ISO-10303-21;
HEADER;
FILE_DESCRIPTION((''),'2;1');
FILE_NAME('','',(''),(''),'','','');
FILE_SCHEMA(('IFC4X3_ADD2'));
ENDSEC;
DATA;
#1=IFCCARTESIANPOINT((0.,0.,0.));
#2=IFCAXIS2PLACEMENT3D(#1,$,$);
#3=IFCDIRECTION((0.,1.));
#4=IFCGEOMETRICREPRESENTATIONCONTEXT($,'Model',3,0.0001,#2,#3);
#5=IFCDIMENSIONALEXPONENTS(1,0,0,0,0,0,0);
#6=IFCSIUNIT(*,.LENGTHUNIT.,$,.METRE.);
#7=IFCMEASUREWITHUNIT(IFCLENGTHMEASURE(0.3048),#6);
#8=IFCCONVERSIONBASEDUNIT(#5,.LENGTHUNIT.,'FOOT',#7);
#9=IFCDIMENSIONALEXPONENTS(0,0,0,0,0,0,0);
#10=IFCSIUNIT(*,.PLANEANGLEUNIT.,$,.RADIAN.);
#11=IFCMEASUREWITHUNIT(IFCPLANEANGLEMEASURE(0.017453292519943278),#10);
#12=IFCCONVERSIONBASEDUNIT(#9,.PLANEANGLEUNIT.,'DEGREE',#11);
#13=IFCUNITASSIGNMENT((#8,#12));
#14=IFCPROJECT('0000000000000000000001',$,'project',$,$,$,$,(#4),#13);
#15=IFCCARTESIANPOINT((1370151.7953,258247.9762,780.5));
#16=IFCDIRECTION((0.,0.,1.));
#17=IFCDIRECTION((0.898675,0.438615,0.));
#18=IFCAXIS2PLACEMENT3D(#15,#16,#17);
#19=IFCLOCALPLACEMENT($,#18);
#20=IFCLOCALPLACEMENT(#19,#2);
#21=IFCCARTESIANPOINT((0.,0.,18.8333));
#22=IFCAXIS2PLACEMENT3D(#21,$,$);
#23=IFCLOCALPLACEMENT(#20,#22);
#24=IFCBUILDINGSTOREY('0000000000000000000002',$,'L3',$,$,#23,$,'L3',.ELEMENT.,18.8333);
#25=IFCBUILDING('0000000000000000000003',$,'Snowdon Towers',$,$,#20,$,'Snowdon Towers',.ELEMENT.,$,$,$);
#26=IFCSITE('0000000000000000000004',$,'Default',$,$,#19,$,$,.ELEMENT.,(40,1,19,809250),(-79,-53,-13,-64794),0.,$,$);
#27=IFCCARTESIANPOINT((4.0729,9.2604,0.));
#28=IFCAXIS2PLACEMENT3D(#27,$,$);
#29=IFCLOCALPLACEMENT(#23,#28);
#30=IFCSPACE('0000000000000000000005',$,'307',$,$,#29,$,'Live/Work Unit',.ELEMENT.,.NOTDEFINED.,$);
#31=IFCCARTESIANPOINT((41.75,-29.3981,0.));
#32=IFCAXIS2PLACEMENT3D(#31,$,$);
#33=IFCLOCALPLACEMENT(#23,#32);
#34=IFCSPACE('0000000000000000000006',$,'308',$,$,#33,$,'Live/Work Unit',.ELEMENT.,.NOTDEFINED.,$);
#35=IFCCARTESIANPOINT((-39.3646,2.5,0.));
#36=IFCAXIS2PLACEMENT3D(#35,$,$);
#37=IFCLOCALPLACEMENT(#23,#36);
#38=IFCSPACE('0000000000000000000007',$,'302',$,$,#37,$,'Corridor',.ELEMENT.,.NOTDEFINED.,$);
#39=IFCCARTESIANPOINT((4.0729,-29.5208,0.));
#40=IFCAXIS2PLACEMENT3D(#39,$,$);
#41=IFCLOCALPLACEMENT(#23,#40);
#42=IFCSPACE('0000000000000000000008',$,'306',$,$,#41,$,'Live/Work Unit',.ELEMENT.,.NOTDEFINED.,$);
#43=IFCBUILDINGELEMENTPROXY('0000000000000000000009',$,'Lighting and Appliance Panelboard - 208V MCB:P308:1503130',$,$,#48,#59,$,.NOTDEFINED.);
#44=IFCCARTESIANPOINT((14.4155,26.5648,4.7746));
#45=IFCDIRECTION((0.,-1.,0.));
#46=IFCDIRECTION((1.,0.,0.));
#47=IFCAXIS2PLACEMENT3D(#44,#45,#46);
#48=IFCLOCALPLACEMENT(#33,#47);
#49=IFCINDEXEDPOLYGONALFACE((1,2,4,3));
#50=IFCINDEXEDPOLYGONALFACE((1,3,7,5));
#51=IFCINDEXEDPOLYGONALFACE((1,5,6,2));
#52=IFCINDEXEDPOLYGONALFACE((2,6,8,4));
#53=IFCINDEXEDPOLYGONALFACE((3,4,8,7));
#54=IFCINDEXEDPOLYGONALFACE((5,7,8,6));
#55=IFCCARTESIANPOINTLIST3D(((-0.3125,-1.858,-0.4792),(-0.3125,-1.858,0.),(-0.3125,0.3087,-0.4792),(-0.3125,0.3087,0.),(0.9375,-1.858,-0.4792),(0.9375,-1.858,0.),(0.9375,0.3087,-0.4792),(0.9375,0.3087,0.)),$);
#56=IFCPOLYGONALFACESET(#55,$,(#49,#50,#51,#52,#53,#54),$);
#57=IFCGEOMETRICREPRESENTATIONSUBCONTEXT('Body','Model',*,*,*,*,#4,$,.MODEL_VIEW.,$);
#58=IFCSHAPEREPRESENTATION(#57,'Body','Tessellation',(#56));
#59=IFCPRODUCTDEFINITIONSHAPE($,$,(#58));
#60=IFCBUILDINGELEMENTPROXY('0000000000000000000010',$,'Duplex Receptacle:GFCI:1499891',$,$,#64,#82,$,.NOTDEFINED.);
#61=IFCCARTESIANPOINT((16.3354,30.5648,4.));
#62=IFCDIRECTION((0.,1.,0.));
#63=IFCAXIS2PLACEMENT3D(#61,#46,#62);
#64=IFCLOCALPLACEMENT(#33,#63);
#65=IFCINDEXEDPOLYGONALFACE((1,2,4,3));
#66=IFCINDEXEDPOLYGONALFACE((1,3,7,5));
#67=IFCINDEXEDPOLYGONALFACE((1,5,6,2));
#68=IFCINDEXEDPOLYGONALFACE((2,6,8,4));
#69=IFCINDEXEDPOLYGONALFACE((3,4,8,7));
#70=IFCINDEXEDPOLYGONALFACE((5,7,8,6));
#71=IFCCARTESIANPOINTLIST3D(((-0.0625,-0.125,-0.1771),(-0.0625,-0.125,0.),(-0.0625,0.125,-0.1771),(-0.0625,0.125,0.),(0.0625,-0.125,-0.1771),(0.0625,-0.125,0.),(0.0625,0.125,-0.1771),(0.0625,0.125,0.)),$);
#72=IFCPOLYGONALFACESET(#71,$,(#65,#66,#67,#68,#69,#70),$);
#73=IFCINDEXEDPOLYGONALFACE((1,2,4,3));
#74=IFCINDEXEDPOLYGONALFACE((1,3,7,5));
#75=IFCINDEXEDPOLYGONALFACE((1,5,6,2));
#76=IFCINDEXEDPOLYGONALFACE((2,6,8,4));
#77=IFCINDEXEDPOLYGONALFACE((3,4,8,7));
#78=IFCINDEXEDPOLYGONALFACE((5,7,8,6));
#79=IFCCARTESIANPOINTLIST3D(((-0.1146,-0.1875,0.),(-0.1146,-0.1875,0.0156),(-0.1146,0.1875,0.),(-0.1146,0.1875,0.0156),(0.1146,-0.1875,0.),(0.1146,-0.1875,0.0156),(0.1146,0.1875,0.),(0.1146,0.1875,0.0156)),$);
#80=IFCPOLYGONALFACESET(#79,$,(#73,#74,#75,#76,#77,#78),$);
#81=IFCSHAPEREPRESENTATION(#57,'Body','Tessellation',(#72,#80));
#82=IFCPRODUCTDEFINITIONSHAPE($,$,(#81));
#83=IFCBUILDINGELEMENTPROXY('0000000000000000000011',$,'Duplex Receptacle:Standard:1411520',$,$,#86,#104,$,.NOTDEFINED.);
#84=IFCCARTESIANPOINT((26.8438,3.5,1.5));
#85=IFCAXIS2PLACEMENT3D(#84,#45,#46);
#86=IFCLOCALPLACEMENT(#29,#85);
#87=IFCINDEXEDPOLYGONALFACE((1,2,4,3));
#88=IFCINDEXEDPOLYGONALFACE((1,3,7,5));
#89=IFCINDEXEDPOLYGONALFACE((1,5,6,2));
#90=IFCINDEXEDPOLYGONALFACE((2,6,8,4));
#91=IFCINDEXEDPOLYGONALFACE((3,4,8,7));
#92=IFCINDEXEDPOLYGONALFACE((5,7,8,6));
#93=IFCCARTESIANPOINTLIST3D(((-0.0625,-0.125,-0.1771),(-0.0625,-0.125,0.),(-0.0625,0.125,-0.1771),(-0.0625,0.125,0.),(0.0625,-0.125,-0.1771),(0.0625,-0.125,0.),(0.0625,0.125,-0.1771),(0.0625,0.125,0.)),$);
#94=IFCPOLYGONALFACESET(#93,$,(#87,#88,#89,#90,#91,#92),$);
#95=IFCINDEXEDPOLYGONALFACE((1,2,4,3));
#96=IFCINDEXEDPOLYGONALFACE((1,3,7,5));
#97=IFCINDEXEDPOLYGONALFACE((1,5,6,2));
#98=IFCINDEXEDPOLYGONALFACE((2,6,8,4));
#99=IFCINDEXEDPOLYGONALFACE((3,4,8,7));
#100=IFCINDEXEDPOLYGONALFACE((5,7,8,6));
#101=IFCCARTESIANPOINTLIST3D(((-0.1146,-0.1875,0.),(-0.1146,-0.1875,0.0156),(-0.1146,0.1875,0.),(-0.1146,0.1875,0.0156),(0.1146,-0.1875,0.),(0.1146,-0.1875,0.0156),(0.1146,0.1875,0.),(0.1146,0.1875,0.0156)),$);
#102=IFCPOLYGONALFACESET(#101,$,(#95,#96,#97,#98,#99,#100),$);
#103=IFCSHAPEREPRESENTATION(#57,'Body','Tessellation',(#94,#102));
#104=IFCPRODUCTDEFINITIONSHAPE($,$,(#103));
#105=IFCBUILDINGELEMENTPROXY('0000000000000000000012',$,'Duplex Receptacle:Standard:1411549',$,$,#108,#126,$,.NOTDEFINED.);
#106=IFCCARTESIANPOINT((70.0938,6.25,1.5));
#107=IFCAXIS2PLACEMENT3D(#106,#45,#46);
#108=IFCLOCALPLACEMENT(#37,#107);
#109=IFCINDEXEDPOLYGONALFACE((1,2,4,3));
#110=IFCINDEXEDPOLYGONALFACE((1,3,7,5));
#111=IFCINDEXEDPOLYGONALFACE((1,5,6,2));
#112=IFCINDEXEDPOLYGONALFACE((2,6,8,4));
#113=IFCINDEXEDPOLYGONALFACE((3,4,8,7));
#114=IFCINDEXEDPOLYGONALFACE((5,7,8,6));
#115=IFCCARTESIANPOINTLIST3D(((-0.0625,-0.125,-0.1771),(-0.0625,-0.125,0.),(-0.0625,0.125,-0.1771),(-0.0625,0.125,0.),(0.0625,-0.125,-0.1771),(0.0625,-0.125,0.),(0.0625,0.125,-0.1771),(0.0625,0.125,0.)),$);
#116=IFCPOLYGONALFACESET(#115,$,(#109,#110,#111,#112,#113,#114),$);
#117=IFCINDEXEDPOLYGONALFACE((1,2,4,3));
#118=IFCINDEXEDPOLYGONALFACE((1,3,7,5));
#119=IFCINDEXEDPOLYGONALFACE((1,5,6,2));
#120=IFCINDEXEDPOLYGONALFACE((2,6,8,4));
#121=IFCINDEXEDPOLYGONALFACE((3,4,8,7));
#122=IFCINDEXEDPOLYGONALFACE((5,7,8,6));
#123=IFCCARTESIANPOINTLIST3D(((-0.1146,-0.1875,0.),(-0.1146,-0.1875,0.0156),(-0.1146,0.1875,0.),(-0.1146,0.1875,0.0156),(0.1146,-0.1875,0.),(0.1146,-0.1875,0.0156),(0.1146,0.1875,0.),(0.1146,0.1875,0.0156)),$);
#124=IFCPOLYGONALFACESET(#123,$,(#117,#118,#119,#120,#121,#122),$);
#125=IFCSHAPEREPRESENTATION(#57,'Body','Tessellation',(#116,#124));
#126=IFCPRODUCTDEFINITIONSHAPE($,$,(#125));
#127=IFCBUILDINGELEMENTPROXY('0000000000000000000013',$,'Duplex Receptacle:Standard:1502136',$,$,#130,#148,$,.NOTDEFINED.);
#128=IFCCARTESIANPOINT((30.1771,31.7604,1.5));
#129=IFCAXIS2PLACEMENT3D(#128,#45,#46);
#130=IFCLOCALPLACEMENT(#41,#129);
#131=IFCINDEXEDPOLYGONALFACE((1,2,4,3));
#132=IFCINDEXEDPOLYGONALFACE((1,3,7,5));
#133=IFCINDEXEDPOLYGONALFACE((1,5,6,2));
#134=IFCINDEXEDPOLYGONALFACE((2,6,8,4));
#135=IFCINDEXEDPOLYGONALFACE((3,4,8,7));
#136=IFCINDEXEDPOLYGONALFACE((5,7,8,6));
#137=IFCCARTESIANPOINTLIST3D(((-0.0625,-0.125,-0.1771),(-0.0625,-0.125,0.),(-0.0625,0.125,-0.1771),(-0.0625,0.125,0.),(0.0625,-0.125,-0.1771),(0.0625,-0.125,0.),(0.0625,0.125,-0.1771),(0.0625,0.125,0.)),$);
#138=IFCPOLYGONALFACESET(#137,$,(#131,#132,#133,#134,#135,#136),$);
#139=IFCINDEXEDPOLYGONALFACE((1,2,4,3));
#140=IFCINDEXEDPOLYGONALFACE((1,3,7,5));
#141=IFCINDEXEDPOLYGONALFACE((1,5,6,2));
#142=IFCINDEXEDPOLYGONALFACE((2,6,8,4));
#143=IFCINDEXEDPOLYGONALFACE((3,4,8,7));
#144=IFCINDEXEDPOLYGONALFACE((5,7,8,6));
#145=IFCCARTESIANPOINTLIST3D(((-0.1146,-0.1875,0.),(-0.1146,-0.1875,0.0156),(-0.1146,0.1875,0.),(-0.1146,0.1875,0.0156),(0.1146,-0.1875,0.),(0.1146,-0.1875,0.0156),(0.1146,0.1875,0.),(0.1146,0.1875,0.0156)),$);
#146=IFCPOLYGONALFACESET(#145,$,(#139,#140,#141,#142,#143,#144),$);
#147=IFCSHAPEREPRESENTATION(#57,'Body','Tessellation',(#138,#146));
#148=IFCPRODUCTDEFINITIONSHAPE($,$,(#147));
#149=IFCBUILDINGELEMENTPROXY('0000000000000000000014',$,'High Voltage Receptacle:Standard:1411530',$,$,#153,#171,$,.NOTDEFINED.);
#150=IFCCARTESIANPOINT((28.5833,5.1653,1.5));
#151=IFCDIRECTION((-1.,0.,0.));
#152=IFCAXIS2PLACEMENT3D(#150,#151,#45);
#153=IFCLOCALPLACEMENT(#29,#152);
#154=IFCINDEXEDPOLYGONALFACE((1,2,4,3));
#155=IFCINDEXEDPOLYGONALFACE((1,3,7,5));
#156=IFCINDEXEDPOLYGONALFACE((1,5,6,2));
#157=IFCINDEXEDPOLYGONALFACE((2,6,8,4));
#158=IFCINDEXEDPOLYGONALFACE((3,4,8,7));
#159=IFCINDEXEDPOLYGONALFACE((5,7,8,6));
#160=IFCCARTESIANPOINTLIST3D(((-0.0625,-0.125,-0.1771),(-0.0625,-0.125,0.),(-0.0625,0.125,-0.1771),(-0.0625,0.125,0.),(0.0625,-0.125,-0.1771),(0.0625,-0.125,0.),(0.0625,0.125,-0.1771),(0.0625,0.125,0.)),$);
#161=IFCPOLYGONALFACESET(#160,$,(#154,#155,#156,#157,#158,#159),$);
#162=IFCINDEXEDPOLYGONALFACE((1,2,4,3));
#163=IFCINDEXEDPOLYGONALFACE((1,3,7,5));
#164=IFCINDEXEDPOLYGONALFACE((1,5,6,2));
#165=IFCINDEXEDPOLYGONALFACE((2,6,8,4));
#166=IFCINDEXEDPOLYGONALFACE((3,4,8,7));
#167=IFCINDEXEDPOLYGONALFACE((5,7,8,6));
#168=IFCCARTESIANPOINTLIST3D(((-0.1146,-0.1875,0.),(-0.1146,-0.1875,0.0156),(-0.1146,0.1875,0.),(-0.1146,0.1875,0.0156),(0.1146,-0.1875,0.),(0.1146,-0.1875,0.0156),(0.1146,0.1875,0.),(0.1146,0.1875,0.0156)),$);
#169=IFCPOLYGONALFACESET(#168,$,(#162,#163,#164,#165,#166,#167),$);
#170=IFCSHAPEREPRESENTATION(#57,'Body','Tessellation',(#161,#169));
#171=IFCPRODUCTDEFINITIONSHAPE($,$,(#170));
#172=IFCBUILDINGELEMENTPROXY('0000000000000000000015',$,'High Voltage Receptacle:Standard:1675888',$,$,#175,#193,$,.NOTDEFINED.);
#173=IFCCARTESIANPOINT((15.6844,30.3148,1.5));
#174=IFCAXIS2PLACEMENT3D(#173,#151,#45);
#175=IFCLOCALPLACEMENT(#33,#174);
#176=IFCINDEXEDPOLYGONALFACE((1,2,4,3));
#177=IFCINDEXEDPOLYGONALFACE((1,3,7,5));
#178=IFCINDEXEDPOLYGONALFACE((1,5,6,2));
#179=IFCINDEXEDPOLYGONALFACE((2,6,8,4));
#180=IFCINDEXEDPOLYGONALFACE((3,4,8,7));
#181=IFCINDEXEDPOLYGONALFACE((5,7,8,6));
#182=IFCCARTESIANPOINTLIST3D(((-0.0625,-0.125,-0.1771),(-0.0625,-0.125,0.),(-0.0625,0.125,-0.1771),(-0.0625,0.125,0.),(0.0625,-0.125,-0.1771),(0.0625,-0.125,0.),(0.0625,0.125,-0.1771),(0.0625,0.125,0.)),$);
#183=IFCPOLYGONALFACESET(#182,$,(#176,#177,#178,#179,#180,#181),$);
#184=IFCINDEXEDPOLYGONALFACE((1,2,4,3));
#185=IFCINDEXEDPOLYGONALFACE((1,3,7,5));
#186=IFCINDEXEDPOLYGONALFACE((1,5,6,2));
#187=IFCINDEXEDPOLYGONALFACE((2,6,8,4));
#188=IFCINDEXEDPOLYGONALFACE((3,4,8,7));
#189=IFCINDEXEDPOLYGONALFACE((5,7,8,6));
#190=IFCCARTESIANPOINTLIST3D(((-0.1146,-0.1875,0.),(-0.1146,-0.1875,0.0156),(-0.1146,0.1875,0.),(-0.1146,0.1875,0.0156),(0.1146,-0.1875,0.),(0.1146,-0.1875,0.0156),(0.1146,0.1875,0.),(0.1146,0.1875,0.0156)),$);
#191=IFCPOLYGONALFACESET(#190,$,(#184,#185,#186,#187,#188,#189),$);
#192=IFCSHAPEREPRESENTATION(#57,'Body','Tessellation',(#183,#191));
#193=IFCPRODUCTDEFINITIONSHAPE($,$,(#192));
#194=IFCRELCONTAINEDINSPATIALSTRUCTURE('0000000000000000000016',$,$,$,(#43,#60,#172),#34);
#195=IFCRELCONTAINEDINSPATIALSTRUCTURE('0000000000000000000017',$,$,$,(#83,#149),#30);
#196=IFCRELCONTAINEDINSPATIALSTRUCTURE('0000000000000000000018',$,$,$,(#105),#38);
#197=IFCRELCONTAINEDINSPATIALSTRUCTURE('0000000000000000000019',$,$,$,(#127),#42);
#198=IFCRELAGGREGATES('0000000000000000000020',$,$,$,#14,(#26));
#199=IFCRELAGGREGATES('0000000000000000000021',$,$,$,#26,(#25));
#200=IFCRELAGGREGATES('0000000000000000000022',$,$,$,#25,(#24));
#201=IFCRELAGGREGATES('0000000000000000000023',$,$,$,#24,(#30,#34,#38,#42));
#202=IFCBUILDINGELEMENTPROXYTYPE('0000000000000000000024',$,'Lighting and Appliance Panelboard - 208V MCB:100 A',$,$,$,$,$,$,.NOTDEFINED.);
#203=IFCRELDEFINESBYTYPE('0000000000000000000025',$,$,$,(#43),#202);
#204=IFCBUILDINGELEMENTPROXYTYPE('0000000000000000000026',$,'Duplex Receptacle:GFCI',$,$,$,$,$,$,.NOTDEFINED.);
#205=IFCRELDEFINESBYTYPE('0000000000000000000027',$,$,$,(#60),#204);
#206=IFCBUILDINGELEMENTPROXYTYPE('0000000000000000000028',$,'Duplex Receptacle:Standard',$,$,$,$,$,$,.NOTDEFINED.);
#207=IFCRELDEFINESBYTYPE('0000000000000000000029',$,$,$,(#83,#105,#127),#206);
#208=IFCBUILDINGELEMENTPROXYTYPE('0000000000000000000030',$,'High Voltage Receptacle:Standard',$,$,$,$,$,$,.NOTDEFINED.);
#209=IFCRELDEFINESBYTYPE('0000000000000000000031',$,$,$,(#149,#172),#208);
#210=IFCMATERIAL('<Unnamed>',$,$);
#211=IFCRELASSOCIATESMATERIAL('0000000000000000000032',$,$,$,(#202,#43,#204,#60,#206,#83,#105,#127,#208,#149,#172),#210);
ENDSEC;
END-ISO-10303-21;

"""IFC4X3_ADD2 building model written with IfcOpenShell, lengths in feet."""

from ifc_helpers import new_model, entity, si_unit, converted_unit, direction, frame, frame_2d, origin, origin_2d_with_axis, place, context, subcontext, project, spatial, rectangle, extrude, source, transform, mapped, material, type_object, type_shapes, element, save


model = new_model("IFC4X3_ADD2")

# Units and contexts
model_context = context("Model", 3, precision=0.0001, world=origin(), true_north=direction((0.0, 1.0)))
body_context = subcontext(model_context, "Body", "Model", "MODEL_VIEW")
ifc_project = project(units=[converted_unit("LENGTHUNIT", "FOOT", entity("IfcLengthMeasure", 0.3048), si_unit("LENGTHUNIT", "METRE"), dimensions=[1, 0, 0, 0, 0, 0, 0]), converted_unit("PLANEANGLEUNIT", "DEGREE", entity("IfcPlaneAngleMeasure", 0.017453292519943278), si_unit("PLANEANGLEUNIT", "RADIAN"), dimensions=[0, 0, 0, 0, 0, 0, 0])], contexts=[model_context])

# Site, building, storey
site_placement = place(None, frame((1370151.7953, 258247.9762, 780.5), z_axis=(0.0, 0.0, 1.0), x_axis=(0.898675, 0.438615, 0.0)))
site = spatial("IfcSite", under=ifc_project, at=site_placement, Name="Default", CompositionType="ELEMENT", RefLatitude=(40, 1, 19, 809250), RefLongitude=(-79, -53, -13, -64794), RefElevation=0.0)
building_placement = place(site_placement, origin())
building = spatial("IfcBuilding", under=site, at=building_placement, Name="Snowdon Towers", LongName="Snowdon Towers", CompositionType="ELEMENT")
storey_placement = place(building_placement, frame((0.0, 0.0, 18.8333)))
storey = spatial("IfcBuildingStorey", under=building, at=storey_placement, Name="L3", LongName="L3", CompositionType="ELEMENT", Elevation=18.8333)

# Shared definitions
space_1_placement = place(storey_placement, frame((4.0729, 9.2604, 0.0)))
space_1 = spatial("IfcSpace", under=storey, at=space_1_placement, Name="307", LongName="Live/Work Unit", CompositionType="ELEMENT", PredefinedType="NOTDEFINED")

# Shared definitions
space_2_placement = place(storey_placement, frame((41.75, -29.3981, 0.0)))
space_2 = spatial("IfcSpace", under=storey, at=space_2_placement, Name="308", LongName="Live/Work Unit", CompositionType="ELEMENT", PredefinedType="NOTDEFINED")

# Building element proxies
ifc_material_1 = material(Name="<Unnamed>")
building_element_proxy_type_1 = type_object("IfcBuildingElementProxyType", Name="Lighting and Appliance Panelboard - 208V MCB:100 A", PredefinedType="NOTDEFINED", material=ifc_material_1)
shared_shape_1 = source(origin(), body_context, "Body", "SweptSolid", [
    extrude(rectangle(XDim=1.25, YDim=2.1667, at=origin_2d_with_axis()), frame((0.3125, -0.7746, -0.4792), z_axis=(0.0, 0.0, 1.0), x_axis=(-1.0, 0.0, 0.0)), (0.0, 0.0, 1.0), 0.4792),
])
type_shapes(building_element_proxy_type_1, [shared_shape_1])
proxy_1_placement = place(space_2_placement, frame((14.4155, 26.5648, 4.7746), z_axis=(0.0, -1.0, 0.0), x_axis=(1.0, 0.0, 0.0)))
element("IfcBuildingElementProxy", 1, at=proxy_1_placement, inside=space_2, type_object=building_element_proxy_type_1, material=ifc_material_1, Name="Lighting and Appliance Panelboard - 208V MCB:P308:1503130", PredefinedType="NOTDEFINED", context=body_context, shape_type="MappedRepresentation", body=[
    mapped(shared_shape_1, transform((0.0, 0.0, 0.0), scale=1.0)),
])
building_element_proxy_type_2 = type_object("IfcBuildingElementProxyType", Name="Duplex Receptacle:GFCI", PredefinedType="NOTDEFINED", material=ifc_material_1)
shared_shape_2 = source(origin(), body_context, "Body", "SweptSolid", [
    extrude(rectangle(XDim=0.125, YDim=0.25, at=origin_2d_with_axis()), frame((0.0, 0.0, -0.1771), z_axis=(0.0, 0.0, 1.0), x_axis=(-1.0, 0.0, 0.0)), (0.0, 0.0, 1.0), 0.1771),
    extrude(rectangle(XDim=0.2292, YDim=0.375, at=frame_2d((0.0, 0.0), x_axis=(1.0, 0.0))), frame((0.0, 0.0, 0.0), z_axis=(0.0, 0.0, 1.0), x_axis=(-1.0, 0.0, 0.0)), (0.0, 0.0, 1.0), 0.0156),
])
type_shapes(building_element_proxy_type_2, [shared_shape_2])
proxy_2_placement = place(space_2_placement, frame((16.3354, 30.5648, 4.0), z_axis=(1.0, 0.0, 0.0), x_axis=(0.0, 1.0, 0.0)))
element("IfcBuildingElementProxy", 2, at=proxy_2_placement, inside=space_2, type_object=building_element_proxy_type_2, material=ifc_material_1, Name="Duplex Receptacle:GFCI:1499891", PredefinedType="NOTDEFINED", context=body_context, shape_type="MappedRepresentation", body=[
    mapped(shared_shape_2, transform((0.0, 0.0, 0.0), scale=1.0)),
])
building_element_proxy_type_3 = type_object("IfcBuildingElementProxyType", Name="Duplex Receptacle:Standard", PredefinedType="NOTDEFINED", material=ifc_material_1)
shared_shape_3 = source(origin(), body_context, "Body", "SweptSolid", [
    extrude(rectangle(XDim=0.125, YDim=0.25, at=origin_2d_with_axis()), frame((0.0, 0.0, -0.1771), z_axis=(0.0, 0.0, 1.0), x_axis=(-1.0, 0.0, 0.0)), (0.0, 0.0, 1.0), 0.1771),
    extrude(rectangle(XDim=0.2292, YDim=0.375, at=frame_2d((0.0, 0.0), x_axis=(1.0, 0.0))), frame((0.0, 0.0, 0.0), z_axis=(0.0, 0.0, 1.0), x_axis=(-1.0, 0.0, 0.0)), (0.0, 0.0, 1.0), 0.0156),
])
type_shapes(building_element_proxy_type_3, [shared_shape_3])
proxy_3_placement = place(space_1_placement, frame((26.8438, 3.5, 1.5), z_axis=(0.0, -1.0, 0.0), x_axis=(1.0, 0.0, 0.0)))
element("IfcBuildingElementProxy", 3, at=proxy_3_placement, inside=space_1, type_object=building_element_proxy_type_3, material=ifc_material_1, Name="Duplex Receptacle:Standard:1411520", PredefinedType="NOTDEFINED", context=body_context, shape_type="MappedRepresentation", body=[
    mapped(shared_shape_3, transform((0.0, 0.0, 0.0), scale=1.0)),
])

# Shared definitions
space_3_placement = place(storey_placement, frame((-39.3646, 2.5, 0.0)))
space_3 = spatial("IfcSpace", under=storey, at=space_3_placement, Name="302", LongName="Corridor", CompositionType="ELEMENT", PredefinedType="NOTDEFINED")

# Building element proxy
proxy_4_placement = place(space_3_placement, frame((70.0938, 6.25, 1.5), z_axis=(0.0, -1.0, 0.0), x_axis=(1.0, 0.0, 0.0)))
element("IfcBuildingElementProxy", 4, at=proxy_4_placement, inside=space_3, type_object=building_element_proxy_type_3, material=ifc_material_1, Name="Duplex Receptacle:Standard:1411549", PredefinedType="NOTDEFINED", context=body_context, shape_type="MappedRepresentation", body=[
    mapped(shared_shape_3, transform((0.0, 0.0, 0.0), scale=1.0)),
])

# Shared definitions
space_4_placement = place(storey_placement, frame((4.0729, -29.5208, 0.0)))
space_4 = spatial("IfcSpace", under=storey, at=space_4_placement, Name="306", LongName="Live/Work Unit", CompositionType="ELEMENT", PredefinedType="NOTDEFINED")

# Building element proxies
proxy_5_placement = place(space_4_placement, frame((30.1771, 31.7604, 1.5), z_axis=(0.0, -1.0, 0.0), x_axis=(1.0, 0.0, 0.0)))
element("IfcBuildingElementProxy", 5, at=proxy_5_placement, inside=space_4, type_object=building_element_proxy_type_3, material=ifc_material_1, Name="Duplex Receptacle:Standard:1502136", PredefinedType="NOTDEFINED", context=body_context, shape_type="MappedRepresentation", body=[
    mapped(shared_shape_3, transform((0.0, 0.0, 0.0), scale=1.0)),
])
building_element_proxy_type_4 = type_object("IfcBuildingElementProxyType", Name="High Voltage Receptacle:Standard", PredefinedType="NOTDEFINED", material=ifc_material_1)
shared_shape_4 = source(origin(), body_context, "Body", "SweptSolid", [
    extrude(rectangle(XDim=0.125, YDim=0.25, at=origin_2d_with_axis()), frame((0.0, 0.0, -0.1771), z_axis=(0.0, 0.0, 1.0), x_axis=(-1.0, 0.0, 0.0)), (0.0, 0.0, 1.0), 0.1771),
    extrude(rectangle(XDim=0.2292, YDim=0.375, at=frame_2d((0.0, 0.0), x_axis=(1.0, 0.0))), frame((0.0, 0.0, 0.0), z_axis=(0.0, 0.0, 1.0), x_axis=(-1.0, 0.0, 0.0)), (0.0, 0.0, 1.0), 0.0156),
])
type_shapes(building_element_proxy_type_4, [shared_shape_4])
proxy_6_placement = place(space_1_placement, frame((28.5833, 5.1653, 1.5), z_axis=(-1.0, 0.0, 0.0), x_axis=(0.0, -1.0, 0.0)))
element("IfcBuildingElementProxy", 6, at=proxy_6_placement, inside=space_1, type_object=building_element_proxy_type_4, material=ifc_material_1, Name="High Voltage Receptacle:Standard:1411530", PredefinedType="NOTDEFINED", context=body_context, shape_type="MappedRepresentation", body=[
    mapped(shared_shape_4, transform((0.0, 0.0, 0.0), scale=1.0)),
])

# Building element proxy
proxy_7_placement = place(space_2_placement, frame((15.6844, 30.3148, 1.5), z_axis=(-1.0, 0.0, 0.0), x_axis=(0.0, -1.0, 0.0)))
element("IfcBuildingElementProxy", 7, at=proxy_7_placement, inside=space_2, type_object=building_element_proxy_type_4, material=ifc_material_1, Name="High Voltage Receptacle:Standard:1675888", PredefinedType="NOTDEFINED", context=body_context, shape_type="MappedRepresentation", body=[
    mapped(shared_shape_4, transform((0.0, 0.0, 0.0), scale=1.0)),
])

save(model, "model.ifc")
